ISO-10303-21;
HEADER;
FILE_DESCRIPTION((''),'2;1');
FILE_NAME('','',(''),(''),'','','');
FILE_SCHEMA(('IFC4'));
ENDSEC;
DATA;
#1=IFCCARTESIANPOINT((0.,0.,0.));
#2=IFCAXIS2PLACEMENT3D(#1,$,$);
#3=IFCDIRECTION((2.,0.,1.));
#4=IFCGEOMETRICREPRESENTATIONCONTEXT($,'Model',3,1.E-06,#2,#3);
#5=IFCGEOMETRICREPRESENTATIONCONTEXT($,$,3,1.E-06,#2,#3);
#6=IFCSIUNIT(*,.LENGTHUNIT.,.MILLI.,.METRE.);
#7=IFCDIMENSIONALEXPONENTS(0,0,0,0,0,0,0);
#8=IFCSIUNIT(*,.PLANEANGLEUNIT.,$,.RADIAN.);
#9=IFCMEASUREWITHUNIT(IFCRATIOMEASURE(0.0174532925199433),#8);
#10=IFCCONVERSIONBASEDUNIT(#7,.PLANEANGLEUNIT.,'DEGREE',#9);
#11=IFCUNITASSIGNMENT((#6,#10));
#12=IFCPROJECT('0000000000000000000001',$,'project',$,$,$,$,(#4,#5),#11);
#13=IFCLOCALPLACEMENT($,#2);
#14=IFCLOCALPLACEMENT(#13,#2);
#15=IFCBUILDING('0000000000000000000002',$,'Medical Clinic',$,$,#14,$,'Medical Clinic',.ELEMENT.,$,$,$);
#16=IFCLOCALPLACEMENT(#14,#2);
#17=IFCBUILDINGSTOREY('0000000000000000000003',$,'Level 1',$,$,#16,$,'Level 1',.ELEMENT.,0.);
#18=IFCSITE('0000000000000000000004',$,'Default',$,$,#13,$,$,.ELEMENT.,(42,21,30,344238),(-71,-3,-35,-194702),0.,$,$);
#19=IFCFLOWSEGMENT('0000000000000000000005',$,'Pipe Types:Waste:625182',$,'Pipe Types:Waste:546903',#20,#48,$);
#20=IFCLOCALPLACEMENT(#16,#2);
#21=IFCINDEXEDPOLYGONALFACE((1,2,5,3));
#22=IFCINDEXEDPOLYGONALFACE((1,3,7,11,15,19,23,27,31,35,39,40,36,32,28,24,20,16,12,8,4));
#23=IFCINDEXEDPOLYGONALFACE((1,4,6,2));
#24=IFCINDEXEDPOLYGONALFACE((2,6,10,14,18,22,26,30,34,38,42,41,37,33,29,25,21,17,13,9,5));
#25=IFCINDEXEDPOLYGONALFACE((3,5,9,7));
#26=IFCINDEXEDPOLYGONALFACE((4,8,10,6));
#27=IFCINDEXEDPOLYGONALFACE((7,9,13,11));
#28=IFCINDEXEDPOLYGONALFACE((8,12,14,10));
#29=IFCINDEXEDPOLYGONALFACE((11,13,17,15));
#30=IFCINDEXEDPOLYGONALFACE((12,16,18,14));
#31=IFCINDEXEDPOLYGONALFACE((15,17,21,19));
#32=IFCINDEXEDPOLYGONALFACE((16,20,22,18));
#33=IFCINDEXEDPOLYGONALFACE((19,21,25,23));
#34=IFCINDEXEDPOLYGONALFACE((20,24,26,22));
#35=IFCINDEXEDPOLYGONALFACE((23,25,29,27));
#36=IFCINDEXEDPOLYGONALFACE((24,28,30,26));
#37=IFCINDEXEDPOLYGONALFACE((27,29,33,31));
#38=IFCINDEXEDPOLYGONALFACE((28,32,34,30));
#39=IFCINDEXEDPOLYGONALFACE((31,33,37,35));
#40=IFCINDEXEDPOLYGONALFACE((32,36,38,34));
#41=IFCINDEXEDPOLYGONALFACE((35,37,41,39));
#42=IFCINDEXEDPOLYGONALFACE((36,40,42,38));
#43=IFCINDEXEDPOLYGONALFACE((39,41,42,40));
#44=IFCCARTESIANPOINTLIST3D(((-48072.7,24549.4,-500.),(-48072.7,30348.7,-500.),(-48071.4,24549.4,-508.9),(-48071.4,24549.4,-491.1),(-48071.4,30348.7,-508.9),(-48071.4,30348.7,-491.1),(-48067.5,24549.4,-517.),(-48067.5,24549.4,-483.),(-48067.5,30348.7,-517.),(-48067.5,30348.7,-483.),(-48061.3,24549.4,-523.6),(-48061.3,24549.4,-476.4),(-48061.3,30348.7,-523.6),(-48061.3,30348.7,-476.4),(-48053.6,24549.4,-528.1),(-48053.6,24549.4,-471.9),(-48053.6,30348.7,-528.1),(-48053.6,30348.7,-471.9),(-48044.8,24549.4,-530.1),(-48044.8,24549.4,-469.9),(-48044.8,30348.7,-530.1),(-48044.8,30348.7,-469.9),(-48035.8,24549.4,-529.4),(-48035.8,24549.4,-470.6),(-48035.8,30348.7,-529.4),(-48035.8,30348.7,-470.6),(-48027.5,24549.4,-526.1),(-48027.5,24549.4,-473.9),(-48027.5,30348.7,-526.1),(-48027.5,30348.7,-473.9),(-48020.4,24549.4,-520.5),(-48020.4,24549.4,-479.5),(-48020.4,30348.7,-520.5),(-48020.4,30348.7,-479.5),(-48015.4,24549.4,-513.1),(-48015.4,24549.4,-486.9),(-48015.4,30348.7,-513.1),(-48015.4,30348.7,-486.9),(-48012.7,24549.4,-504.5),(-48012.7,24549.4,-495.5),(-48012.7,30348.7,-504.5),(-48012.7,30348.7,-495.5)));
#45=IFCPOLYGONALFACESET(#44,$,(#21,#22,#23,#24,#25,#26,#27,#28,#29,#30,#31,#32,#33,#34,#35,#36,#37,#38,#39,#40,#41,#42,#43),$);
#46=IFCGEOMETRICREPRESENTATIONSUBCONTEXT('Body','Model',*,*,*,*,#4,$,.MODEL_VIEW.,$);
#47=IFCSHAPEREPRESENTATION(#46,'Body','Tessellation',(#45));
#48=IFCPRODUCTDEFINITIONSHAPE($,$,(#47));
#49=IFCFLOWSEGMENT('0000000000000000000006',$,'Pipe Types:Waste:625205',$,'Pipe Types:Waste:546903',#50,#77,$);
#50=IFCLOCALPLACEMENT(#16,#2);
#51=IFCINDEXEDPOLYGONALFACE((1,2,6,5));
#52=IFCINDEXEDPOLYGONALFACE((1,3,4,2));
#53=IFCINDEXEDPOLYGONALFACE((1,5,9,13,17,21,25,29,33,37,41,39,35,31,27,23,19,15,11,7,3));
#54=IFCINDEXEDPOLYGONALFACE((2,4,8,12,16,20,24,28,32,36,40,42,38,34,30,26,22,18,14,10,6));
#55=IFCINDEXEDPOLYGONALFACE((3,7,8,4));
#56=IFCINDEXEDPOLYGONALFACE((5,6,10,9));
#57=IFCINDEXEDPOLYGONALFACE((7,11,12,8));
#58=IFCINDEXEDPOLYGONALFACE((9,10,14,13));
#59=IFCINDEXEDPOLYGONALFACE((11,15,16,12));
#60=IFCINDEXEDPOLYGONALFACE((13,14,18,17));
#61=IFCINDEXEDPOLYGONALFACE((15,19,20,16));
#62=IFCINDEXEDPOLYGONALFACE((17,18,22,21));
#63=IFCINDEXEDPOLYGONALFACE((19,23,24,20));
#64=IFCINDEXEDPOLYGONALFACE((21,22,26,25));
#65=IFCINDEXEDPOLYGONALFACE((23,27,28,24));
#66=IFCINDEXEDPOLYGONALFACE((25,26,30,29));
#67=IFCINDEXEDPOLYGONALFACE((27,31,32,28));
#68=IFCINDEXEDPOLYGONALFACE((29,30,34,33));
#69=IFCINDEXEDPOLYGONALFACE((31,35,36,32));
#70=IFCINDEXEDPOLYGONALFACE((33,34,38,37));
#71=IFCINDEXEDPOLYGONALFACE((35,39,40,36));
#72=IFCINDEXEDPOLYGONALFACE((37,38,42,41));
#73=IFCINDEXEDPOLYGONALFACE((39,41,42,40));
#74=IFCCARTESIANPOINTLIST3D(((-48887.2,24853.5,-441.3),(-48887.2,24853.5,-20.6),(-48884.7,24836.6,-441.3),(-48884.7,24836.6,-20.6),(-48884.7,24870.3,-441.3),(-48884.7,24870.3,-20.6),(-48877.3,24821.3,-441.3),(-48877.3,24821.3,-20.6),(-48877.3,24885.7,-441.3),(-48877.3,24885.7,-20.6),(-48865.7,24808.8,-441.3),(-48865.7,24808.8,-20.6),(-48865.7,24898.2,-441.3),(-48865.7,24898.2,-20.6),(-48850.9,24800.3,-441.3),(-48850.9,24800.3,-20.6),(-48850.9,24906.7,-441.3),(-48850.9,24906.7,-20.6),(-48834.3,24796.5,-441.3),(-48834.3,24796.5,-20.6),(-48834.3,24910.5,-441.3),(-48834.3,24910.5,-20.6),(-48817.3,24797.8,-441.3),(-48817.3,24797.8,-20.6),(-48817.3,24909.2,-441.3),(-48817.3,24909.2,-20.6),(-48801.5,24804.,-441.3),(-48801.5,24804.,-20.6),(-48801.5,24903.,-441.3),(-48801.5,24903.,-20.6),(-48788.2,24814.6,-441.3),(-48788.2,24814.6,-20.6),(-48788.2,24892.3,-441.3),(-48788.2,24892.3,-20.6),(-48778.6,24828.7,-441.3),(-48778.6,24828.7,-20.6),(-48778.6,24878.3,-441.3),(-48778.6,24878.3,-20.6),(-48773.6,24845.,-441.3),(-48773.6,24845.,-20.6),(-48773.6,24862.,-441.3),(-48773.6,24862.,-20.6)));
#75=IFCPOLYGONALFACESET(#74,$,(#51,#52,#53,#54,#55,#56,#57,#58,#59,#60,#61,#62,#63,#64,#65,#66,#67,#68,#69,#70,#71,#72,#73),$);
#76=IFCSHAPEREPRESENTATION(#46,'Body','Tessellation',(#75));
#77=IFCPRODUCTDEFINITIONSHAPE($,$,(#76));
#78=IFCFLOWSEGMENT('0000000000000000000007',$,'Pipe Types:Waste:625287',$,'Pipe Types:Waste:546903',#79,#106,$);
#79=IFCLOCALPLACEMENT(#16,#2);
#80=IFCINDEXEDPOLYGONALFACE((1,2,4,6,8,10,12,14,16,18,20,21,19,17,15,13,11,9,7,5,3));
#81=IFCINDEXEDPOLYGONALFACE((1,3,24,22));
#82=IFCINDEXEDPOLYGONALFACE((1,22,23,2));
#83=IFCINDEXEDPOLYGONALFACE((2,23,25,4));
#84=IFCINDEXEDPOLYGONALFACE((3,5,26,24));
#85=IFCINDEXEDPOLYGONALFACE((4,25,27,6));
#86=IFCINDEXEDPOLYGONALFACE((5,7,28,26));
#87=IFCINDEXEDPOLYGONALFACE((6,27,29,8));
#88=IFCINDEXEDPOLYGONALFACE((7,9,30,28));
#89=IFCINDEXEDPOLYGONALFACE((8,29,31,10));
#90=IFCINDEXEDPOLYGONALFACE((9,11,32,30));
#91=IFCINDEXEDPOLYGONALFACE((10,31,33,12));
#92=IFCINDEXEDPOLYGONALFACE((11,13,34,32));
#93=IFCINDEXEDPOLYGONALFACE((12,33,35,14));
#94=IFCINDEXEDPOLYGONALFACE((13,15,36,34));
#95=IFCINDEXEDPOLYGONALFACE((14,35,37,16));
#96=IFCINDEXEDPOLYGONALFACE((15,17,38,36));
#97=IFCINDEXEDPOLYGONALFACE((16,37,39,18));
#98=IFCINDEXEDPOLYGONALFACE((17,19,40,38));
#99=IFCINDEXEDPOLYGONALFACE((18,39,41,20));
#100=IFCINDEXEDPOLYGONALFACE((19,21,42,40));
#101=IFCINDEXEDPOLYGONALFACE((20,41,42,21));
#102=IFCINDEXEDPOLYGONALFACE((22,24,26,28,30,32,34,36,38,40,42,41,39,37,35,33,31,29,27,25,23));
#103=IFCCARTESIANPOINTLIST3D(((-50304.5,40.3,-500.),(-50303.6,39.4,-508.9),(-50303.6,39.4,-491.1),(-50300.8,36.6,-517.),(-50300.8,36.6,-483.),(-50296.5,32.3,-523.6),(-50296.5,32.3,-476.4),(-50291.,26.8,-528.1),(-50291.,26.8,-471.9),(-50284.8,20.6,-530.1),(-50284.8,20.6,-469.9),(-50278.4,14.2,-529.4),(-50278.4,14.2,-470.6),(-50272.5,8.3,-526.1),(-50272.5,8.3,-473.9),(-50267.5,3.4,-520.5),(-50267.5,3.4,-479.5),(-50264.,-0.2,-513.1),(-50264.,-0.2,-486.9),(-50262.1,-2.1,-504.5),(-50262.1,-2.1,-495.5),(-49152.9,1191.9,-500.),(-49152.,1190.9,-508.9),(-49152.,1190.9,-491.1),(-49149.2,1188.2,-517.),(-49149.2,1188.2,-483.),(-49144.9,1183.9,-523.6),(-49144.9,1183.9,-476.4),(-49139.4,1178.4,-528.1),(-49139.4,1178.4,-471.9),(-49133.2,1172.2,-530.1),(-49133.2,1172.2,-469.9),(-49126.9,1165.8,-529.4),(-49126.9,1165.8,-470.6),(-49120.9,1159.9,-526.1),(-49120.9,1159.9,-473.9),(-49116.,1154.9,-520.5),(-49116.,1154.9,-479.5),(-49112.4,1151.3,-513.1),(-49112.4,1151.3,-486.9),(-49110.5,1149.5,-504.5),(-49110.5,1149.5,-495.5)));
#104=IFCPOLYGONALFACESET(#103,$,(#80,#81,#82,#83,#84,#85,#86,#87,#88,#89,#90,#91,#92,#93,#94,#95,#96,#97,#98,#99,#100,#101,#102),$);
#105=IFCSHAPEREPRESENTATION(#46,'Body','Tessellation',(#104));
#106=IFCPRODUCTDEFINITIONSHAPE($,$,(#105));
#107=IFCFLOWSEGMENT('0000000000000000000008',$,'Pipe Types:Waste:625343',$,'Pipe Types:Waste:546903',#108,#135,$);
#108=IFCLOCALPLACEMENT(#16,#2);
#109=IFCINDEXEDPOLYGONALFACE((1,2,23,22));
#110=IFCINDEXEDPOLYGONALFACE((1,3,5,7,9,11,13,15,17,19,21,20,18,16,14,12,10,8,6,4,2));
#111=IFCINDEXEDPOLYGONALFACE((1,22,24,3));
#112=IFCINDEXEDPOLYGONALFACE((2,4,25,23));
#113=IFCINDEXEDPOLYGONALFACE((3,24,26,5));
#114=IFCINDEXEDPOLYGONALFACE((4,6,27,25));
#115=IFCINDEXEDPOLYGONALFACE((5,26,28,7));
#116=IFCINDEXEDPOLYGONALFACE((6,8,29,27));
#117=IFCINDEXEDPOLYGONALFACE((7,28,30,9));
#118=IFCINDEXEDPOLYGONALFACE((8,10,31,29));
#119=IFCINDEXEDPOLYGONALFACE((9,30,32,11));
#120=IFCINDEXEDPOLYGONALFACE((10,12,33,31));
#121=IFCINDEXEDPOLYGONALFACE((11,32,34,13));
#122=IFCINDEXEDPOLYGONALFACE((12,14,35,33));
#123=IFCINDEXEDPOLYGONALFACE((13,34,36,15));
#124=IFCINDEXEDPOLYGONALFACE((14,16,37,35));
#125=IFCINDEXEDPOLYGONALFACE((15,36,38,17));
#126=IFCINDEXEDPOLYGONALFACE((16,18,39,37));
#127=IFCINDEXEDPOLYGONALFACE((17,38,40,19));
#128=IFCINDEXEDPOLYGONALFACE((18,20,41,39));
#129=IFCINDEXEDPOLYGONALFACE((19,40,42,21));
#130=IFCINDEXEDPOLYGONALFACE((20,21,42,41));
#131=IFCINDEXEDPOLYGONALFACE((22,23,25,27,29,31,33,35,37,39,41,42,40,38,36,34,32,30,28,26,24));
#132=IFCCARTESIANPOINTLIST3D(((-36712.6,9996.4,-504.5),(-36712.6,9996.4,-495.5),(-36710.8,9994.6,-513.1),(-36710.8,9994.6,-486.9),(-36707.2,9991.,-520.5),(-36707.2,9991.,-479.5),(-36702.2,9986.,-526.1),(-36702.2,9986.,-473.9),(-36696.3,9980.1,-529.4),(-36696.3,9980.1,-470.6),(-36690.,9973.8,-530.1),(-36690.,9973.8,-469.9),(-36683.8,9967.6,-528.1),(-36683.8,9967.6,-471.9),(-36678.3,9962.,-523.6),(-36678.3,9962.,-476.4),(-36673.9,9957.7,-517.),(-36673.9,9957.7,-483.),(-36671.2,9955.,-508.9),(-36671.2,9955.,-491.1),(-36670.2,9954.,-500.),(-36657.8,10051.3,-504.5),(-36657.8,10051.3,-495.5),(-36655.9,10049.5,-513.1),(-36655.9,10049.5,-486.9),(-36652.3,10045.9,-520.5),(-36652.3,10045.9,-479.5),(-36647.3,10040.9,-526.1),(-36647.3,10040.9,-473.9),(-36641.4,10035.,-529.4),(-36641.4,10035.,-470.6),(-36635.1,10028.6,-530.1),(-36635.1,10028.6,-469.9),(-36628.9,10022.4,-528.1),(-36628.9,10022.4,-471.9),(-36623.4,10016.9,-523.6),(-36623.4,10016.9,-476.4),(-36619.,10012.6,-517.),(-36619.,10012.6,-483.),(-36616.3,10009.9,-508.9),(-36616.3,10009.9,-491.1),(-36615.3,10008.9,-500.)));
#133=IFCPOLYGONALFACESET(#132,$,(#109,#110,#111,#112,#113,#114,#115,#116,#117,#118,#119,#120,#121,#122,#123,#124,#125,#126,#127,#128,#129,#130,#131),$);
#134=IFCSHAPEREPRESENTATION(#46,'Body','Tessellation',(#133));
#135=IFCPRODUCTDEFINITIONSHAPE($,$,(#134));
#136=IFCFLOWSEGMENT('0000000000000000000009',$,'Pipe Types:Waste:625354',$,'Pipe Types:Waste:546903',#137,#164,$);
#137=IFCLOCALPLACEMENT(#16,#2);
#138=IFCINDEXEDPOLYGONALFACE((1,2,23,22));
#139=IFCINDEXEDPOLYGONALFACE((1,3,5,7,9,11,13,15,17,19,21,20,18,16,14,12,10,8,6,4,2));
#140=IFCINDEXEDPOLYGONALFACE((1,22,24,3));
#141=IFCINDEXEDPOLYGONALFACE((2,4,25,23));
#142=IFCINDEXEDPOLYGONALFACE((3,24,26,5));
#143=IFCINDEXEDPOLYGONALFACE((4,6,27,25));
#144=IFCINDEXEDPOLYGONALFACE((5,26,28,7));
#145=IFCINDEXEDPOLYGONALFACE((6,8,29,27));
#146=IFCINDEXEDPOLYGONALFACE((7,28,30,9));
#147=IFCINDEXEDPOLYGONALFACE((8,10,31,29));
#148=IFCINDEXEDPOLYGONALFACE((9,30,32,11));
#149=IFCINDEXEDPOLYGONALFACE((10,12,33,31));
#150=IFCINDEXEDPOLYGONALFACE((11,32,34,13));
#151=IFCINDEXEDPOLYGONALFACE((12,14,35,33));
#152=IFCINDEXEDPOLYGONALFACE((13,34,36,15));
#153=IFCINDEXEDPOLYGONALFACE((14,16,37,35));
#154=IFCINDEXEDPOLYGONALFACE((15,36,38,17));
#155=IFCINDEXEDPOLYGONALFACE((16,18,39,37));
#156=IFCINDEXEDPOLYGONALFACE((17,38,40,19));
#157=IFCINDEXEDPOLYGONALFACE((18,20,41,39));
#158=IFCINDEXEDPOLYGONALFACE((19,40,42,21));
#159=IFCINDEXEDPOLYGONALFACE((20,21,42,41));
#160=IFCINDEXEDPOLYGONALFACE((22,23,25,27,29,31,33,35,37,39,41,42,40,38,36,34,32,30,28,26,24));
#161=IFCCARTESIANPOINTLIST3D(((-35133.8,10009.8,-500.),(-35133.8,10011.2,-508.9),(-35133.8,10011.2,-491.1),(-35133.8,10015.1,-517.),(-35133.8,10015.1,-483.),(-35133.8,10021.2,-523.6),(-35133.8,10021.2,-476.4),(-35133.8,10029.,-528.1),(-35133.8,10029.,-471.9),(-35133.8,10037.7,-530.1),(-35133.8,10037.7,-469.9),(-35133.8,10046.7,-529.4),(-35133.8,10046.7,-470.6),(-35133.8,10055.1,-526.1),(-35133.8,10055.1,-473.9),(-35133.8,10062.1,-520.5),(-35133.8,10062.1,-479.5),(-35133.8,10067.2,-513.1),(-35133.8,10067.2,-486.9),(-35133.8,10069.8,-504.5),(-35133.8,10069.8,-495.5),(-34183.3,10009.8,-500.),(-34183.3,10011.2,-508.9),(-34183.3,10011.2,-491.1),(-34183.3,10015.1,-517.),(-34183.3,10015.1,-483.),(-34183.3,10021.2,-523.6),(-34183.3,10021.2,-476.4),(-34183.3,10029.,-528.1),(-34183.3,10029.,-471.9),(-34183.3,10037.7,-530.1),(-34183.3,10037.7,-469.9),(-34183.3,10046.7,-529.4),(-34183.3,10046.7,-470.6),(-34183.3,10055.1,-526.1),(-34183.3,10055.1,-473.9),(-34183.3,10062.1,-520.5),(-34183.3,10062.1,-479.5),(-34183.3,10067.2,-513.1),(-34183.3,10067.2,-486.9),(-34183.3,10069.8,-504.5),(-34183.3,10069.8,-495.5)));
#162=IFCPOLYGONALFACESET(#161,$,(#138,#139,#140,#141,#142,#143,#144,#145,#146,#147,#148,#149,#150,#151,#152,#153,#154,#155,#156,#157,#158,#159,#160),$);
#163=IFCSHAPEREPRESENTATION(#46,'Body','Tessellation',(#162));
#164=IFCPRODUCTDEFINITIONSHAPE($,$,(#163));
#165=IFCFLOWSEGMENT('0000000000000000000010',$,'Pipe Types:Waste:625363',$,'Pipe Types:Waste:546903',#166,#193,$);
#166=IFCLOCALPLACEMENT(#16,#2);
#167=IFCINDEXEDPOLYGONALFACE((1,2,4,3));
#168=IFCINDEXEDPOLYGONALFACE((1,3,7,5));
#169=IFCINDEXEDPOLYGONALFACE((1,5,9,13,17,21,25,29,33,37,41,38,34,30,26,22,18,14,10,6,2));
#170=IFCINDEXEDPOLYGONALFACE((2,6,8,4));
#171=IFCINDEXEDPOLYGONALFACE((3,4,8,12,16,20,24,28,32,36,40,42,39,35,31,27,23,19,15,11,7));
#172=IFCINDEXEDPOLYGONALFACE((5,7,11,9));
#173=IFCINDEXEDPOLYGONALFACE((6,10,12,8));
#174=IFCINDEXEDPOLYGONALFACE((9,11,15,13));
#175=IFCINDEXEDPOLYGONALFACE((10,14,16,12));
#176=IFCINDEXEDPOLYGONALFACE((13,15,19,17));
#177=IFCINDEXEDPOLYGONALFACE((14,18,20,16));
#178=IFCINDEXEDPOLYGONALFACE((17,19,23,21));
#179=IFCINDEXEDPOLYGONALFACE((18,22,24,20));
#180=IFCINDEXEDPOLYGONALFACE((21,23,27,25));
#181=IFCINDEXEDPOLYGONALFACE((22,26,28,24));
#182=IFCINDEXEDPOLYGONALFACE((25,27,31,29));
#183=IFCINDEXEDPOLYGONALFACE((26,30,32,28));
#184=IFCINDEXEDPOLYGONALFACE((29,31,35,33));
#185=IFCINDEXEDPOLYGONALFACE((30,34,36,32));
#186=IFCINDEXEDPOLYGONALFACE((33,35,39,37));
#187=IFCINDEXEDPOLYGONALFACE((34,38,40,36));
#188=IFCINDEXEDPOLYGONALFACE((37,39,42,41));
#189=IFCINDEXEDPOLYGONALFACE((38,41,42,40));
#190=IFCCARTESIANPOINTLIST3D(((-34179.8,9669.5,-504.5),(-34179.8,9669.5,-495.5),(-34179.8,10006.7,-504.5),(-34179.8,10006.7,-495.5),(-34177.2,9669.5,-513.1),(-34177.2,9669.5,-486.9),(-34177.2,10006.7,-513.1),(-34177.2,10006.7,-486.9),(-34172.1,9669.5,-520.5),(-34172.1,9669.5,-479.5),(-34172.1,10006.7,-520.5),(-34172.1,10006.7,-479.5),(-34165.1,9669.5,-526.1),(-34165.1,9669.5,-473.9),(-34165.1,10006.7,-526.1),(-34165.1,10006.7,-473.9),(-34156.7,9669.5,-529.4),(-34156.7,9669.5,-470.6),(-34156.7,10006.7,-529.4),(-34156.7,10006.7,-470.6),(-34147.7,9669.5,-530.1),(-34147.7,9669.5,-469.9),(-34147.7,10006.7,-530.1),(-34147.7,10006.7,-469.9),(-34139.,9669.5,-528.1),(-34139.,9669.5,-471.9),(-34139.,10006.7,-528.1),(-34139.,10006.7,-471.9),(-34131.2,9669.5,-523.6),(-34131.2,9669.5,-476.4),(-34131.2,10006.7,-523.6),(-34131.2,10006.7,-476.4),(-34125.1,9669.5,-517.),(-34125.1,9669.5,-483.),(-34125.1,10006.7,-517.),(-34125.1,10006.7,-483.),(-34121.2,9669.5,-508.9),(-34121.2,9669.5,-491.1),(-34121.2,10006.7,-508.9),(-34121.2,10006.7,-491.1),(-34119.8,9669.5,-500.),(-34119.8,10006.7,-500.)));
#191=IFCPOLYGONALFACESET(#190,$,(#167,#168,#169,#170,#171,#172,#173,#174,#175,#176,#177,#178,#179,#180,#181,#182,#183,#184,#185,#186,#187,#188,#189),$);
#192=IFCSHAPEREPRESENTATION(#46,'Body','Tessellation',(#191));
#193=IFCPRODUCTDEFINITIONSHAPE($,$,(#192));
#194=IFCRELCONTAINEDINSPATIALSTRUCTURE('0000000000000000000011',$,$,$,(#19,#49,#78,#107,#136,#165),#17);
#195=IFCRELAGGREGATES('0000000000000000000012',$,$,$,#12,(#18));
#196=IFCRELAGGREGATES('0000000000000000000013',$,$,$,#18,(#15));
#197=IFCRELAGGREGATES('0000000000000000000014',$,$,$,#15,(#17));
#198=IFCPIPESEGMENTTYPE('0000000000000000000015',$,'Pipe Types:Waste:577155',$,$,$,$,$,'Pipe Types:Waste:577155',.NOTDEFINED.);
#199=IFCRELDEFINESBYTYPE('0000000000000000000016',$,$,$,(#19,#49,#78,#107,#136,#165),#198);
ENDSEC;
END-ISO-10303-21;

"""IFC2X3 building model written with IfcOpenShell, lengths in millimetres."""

from ifc_helpers import new_model, entity, si_unit, converted_unit, direction, frame, frame_2d, origin, origin_2d_with_axis, place, context, subcontext, project, spatial, circle, extrude, type_object, element, save


model = new_model("IFC2X3")

# Units and contexts
model_context = context("Model", 3, precision=1e-06, world=origin(), true_north=direction((2.0, 0.0, 1.0)))
context_of_model = context(None, 3, precision=1e-06, world=origin(), true_north=direction((2.0, 0.0, 1.0)))
body_context = subcontext(model_context, "Body", "Model", "MODEL_VIEW")
ifc_project = project(units=[si_unit("LENGTHUNIT", "METRE", prefix="MILLI"), converted_unit("PLANEANGLEUNIT", "DEGREE", entity("IfcRatioMeasure", 0.0174532925199433), si_unit("PLANEANGLEUNIT", "RADIAN"), dimensions=[0, 0, 0, 0, 0, 0, 0])], contexts=[model_context, context_of_model])

# Site, building, storey
site_placement = place(None, origin())
site = spatial("IfcSite", under=ifc_project, at=site_placement, Name="Default", CompositionType="ELEMENT", RefLatitude=(42, 21, 30, 344238), RefLongitude=(-71, -3, -35, -194702), RefElevation=0.0)
building_placement = place(site_placement, origin())
building = spatial("IfcBuilding", under=site, at=building_placement, Name="Medical Clinic", LongName="Medical Clinic", CompositionType="ELEMENT")
storey_placement = place(building_placement, origin())
storey = spatial("IfcBuildingStorey", under=building, at=storey_placement, Name="Level 1", LongName="Level 1", CompositionType="ELEMENT", Elevation=0.0)

# Flow segments
pipe_segment_type = type_object("IfcPipeSegmentType", Name="Pipe Types:Waste:577155", ElementType="Pipe Types:Waste:577155", PredefinedType="NOTDEFINED")
flow_segment_1_placement = place(storey_placement, origin())
element("IfcFlowSegment", 1, at=flow_segment_1_placement, inside=storey, type_object=pipe_segment_type, Name="Pipe Types:Waste:625182", ObjectType="Pipe Types:Waste:546903", context=body_context, shape_type="SweptSolid", body=[
    extrude(circle(Radius=30.2, at=origin_2d_with_axis()), frame((-48042.5, 24549.4, -500.0), z_axis=(0.0, 1.0, 0.0), x_axis=(-1.0, 0.0, 0.0)), (0.0, 0.0, 1.0), 5799.3),
])
flow_segment_2_placement = place(storey_placement, origin())
element("IfcFlowSegment", 2, at=flow_segment_2_placement, inside=storey, type_object=pipe_segment_type, Name="Pipe Types:Waste:625205", ObjectType="Pipe Types:Waste:546903", context=body_context, shape_type="SweptSolid", body=[
    extrude(circle(Radius=57.1, at=origin_2d_with_axis()), frame((-48830.1, 24853.5, -441.3), z_axis=(0.0, 0.0, 1.0), x_axis=(-1.0, 0.0, 0.0)), (0.0, 0.0, 1.0), 420.6),
])
flow_segment_3_placement = place(storey_placement, origin())
element("IfcFlowSegment", 3, at=flow_segment_3_placement, inside=storey, type_object=pipe_segment_type, Name="Pipe Types:Waste:625287", ObjectType="Pipe Types:Waste:546903", context=body_context, shape_type="SweptSolid", body=[
    extrude(circle(Radius=30.2, at=frame_2d((0.0, 0.0), x_axis=(1.0, 0.0))), frame((-50283.2, 19.0, -500.0), z_axis=(0.707105, 0.707109, 0.0), x_axis=(-0.707109, 0.707105, 0.0)), (0.0, 0.0, 1.0), 1628.6),
])
flow_segment_4_placement = place(storey_placement, origin())
element("IfcFlowSegment", 4, at=flow_segment_4_placement, inside=storey, type_object=pipe_segment_type, Name="Pipe Types:Waste:625343", ObjectType="Pipe Types:Waste:546903", context=body_context, shape_type="SweptSolid", body=[
    extrude(circle(Radius=30.2, at=origin_2d_with_axis()), frame((-36691.6, 9975.3, -500.0), z_axis=(0.707107, 0.707107, 0.0), x_axis=(0.707107, -0.707107, 0.0)), (0.0, 0.0, 1.0), 77.6),
])
flow_segment_5_placement = place(storey_placement, origin())
element("IfcFlowSegment", 5, at=flow_segment_5_placement, inside=storey, type_object=pipe_segment_type, Name="Pipe Types:Waste:625354", ObjectType="Pipe Types:Waste:546903", context=body_context, shape_type="SweptSolid", body=[
    extrude(circle(Radius=30.2, at=frame_2d((0.0, 0.0), x_axis=(1.0, 0.0))), frame((-35133.8, 10040.0, -500.0), z_axis=(1.0, 0.0, 0.0), x_axis=(0.0, -1.0, 0.0)), (0.0, 0.0, 1.0), 950.5),
])
flow_segment_6_placement = place(storey_placement, origin())
element("IfcFlowSegment", 6, at=flow_segment_6_placement, inside=storey, type_object=pipe_segment_type, Name="Pipe Types:Waste:625363", ObjectType="Pipe Types:Waste:546903", context=body_context, shape_type="SweptSolid", body=[
    extrude(circle(Radius=30.2, at=frame_2d((0.0, 0.0), x_axis=(1.0, 0.0))), frame((-34150.0, 9669.5, -500.0), z_axis=(0.0, 1.0, 0.0), x_axis=(1.0, 0.0, 0.0)), (0.0, 0.0, 1.0), 337.2),
])

save(model, "model.ifc")
